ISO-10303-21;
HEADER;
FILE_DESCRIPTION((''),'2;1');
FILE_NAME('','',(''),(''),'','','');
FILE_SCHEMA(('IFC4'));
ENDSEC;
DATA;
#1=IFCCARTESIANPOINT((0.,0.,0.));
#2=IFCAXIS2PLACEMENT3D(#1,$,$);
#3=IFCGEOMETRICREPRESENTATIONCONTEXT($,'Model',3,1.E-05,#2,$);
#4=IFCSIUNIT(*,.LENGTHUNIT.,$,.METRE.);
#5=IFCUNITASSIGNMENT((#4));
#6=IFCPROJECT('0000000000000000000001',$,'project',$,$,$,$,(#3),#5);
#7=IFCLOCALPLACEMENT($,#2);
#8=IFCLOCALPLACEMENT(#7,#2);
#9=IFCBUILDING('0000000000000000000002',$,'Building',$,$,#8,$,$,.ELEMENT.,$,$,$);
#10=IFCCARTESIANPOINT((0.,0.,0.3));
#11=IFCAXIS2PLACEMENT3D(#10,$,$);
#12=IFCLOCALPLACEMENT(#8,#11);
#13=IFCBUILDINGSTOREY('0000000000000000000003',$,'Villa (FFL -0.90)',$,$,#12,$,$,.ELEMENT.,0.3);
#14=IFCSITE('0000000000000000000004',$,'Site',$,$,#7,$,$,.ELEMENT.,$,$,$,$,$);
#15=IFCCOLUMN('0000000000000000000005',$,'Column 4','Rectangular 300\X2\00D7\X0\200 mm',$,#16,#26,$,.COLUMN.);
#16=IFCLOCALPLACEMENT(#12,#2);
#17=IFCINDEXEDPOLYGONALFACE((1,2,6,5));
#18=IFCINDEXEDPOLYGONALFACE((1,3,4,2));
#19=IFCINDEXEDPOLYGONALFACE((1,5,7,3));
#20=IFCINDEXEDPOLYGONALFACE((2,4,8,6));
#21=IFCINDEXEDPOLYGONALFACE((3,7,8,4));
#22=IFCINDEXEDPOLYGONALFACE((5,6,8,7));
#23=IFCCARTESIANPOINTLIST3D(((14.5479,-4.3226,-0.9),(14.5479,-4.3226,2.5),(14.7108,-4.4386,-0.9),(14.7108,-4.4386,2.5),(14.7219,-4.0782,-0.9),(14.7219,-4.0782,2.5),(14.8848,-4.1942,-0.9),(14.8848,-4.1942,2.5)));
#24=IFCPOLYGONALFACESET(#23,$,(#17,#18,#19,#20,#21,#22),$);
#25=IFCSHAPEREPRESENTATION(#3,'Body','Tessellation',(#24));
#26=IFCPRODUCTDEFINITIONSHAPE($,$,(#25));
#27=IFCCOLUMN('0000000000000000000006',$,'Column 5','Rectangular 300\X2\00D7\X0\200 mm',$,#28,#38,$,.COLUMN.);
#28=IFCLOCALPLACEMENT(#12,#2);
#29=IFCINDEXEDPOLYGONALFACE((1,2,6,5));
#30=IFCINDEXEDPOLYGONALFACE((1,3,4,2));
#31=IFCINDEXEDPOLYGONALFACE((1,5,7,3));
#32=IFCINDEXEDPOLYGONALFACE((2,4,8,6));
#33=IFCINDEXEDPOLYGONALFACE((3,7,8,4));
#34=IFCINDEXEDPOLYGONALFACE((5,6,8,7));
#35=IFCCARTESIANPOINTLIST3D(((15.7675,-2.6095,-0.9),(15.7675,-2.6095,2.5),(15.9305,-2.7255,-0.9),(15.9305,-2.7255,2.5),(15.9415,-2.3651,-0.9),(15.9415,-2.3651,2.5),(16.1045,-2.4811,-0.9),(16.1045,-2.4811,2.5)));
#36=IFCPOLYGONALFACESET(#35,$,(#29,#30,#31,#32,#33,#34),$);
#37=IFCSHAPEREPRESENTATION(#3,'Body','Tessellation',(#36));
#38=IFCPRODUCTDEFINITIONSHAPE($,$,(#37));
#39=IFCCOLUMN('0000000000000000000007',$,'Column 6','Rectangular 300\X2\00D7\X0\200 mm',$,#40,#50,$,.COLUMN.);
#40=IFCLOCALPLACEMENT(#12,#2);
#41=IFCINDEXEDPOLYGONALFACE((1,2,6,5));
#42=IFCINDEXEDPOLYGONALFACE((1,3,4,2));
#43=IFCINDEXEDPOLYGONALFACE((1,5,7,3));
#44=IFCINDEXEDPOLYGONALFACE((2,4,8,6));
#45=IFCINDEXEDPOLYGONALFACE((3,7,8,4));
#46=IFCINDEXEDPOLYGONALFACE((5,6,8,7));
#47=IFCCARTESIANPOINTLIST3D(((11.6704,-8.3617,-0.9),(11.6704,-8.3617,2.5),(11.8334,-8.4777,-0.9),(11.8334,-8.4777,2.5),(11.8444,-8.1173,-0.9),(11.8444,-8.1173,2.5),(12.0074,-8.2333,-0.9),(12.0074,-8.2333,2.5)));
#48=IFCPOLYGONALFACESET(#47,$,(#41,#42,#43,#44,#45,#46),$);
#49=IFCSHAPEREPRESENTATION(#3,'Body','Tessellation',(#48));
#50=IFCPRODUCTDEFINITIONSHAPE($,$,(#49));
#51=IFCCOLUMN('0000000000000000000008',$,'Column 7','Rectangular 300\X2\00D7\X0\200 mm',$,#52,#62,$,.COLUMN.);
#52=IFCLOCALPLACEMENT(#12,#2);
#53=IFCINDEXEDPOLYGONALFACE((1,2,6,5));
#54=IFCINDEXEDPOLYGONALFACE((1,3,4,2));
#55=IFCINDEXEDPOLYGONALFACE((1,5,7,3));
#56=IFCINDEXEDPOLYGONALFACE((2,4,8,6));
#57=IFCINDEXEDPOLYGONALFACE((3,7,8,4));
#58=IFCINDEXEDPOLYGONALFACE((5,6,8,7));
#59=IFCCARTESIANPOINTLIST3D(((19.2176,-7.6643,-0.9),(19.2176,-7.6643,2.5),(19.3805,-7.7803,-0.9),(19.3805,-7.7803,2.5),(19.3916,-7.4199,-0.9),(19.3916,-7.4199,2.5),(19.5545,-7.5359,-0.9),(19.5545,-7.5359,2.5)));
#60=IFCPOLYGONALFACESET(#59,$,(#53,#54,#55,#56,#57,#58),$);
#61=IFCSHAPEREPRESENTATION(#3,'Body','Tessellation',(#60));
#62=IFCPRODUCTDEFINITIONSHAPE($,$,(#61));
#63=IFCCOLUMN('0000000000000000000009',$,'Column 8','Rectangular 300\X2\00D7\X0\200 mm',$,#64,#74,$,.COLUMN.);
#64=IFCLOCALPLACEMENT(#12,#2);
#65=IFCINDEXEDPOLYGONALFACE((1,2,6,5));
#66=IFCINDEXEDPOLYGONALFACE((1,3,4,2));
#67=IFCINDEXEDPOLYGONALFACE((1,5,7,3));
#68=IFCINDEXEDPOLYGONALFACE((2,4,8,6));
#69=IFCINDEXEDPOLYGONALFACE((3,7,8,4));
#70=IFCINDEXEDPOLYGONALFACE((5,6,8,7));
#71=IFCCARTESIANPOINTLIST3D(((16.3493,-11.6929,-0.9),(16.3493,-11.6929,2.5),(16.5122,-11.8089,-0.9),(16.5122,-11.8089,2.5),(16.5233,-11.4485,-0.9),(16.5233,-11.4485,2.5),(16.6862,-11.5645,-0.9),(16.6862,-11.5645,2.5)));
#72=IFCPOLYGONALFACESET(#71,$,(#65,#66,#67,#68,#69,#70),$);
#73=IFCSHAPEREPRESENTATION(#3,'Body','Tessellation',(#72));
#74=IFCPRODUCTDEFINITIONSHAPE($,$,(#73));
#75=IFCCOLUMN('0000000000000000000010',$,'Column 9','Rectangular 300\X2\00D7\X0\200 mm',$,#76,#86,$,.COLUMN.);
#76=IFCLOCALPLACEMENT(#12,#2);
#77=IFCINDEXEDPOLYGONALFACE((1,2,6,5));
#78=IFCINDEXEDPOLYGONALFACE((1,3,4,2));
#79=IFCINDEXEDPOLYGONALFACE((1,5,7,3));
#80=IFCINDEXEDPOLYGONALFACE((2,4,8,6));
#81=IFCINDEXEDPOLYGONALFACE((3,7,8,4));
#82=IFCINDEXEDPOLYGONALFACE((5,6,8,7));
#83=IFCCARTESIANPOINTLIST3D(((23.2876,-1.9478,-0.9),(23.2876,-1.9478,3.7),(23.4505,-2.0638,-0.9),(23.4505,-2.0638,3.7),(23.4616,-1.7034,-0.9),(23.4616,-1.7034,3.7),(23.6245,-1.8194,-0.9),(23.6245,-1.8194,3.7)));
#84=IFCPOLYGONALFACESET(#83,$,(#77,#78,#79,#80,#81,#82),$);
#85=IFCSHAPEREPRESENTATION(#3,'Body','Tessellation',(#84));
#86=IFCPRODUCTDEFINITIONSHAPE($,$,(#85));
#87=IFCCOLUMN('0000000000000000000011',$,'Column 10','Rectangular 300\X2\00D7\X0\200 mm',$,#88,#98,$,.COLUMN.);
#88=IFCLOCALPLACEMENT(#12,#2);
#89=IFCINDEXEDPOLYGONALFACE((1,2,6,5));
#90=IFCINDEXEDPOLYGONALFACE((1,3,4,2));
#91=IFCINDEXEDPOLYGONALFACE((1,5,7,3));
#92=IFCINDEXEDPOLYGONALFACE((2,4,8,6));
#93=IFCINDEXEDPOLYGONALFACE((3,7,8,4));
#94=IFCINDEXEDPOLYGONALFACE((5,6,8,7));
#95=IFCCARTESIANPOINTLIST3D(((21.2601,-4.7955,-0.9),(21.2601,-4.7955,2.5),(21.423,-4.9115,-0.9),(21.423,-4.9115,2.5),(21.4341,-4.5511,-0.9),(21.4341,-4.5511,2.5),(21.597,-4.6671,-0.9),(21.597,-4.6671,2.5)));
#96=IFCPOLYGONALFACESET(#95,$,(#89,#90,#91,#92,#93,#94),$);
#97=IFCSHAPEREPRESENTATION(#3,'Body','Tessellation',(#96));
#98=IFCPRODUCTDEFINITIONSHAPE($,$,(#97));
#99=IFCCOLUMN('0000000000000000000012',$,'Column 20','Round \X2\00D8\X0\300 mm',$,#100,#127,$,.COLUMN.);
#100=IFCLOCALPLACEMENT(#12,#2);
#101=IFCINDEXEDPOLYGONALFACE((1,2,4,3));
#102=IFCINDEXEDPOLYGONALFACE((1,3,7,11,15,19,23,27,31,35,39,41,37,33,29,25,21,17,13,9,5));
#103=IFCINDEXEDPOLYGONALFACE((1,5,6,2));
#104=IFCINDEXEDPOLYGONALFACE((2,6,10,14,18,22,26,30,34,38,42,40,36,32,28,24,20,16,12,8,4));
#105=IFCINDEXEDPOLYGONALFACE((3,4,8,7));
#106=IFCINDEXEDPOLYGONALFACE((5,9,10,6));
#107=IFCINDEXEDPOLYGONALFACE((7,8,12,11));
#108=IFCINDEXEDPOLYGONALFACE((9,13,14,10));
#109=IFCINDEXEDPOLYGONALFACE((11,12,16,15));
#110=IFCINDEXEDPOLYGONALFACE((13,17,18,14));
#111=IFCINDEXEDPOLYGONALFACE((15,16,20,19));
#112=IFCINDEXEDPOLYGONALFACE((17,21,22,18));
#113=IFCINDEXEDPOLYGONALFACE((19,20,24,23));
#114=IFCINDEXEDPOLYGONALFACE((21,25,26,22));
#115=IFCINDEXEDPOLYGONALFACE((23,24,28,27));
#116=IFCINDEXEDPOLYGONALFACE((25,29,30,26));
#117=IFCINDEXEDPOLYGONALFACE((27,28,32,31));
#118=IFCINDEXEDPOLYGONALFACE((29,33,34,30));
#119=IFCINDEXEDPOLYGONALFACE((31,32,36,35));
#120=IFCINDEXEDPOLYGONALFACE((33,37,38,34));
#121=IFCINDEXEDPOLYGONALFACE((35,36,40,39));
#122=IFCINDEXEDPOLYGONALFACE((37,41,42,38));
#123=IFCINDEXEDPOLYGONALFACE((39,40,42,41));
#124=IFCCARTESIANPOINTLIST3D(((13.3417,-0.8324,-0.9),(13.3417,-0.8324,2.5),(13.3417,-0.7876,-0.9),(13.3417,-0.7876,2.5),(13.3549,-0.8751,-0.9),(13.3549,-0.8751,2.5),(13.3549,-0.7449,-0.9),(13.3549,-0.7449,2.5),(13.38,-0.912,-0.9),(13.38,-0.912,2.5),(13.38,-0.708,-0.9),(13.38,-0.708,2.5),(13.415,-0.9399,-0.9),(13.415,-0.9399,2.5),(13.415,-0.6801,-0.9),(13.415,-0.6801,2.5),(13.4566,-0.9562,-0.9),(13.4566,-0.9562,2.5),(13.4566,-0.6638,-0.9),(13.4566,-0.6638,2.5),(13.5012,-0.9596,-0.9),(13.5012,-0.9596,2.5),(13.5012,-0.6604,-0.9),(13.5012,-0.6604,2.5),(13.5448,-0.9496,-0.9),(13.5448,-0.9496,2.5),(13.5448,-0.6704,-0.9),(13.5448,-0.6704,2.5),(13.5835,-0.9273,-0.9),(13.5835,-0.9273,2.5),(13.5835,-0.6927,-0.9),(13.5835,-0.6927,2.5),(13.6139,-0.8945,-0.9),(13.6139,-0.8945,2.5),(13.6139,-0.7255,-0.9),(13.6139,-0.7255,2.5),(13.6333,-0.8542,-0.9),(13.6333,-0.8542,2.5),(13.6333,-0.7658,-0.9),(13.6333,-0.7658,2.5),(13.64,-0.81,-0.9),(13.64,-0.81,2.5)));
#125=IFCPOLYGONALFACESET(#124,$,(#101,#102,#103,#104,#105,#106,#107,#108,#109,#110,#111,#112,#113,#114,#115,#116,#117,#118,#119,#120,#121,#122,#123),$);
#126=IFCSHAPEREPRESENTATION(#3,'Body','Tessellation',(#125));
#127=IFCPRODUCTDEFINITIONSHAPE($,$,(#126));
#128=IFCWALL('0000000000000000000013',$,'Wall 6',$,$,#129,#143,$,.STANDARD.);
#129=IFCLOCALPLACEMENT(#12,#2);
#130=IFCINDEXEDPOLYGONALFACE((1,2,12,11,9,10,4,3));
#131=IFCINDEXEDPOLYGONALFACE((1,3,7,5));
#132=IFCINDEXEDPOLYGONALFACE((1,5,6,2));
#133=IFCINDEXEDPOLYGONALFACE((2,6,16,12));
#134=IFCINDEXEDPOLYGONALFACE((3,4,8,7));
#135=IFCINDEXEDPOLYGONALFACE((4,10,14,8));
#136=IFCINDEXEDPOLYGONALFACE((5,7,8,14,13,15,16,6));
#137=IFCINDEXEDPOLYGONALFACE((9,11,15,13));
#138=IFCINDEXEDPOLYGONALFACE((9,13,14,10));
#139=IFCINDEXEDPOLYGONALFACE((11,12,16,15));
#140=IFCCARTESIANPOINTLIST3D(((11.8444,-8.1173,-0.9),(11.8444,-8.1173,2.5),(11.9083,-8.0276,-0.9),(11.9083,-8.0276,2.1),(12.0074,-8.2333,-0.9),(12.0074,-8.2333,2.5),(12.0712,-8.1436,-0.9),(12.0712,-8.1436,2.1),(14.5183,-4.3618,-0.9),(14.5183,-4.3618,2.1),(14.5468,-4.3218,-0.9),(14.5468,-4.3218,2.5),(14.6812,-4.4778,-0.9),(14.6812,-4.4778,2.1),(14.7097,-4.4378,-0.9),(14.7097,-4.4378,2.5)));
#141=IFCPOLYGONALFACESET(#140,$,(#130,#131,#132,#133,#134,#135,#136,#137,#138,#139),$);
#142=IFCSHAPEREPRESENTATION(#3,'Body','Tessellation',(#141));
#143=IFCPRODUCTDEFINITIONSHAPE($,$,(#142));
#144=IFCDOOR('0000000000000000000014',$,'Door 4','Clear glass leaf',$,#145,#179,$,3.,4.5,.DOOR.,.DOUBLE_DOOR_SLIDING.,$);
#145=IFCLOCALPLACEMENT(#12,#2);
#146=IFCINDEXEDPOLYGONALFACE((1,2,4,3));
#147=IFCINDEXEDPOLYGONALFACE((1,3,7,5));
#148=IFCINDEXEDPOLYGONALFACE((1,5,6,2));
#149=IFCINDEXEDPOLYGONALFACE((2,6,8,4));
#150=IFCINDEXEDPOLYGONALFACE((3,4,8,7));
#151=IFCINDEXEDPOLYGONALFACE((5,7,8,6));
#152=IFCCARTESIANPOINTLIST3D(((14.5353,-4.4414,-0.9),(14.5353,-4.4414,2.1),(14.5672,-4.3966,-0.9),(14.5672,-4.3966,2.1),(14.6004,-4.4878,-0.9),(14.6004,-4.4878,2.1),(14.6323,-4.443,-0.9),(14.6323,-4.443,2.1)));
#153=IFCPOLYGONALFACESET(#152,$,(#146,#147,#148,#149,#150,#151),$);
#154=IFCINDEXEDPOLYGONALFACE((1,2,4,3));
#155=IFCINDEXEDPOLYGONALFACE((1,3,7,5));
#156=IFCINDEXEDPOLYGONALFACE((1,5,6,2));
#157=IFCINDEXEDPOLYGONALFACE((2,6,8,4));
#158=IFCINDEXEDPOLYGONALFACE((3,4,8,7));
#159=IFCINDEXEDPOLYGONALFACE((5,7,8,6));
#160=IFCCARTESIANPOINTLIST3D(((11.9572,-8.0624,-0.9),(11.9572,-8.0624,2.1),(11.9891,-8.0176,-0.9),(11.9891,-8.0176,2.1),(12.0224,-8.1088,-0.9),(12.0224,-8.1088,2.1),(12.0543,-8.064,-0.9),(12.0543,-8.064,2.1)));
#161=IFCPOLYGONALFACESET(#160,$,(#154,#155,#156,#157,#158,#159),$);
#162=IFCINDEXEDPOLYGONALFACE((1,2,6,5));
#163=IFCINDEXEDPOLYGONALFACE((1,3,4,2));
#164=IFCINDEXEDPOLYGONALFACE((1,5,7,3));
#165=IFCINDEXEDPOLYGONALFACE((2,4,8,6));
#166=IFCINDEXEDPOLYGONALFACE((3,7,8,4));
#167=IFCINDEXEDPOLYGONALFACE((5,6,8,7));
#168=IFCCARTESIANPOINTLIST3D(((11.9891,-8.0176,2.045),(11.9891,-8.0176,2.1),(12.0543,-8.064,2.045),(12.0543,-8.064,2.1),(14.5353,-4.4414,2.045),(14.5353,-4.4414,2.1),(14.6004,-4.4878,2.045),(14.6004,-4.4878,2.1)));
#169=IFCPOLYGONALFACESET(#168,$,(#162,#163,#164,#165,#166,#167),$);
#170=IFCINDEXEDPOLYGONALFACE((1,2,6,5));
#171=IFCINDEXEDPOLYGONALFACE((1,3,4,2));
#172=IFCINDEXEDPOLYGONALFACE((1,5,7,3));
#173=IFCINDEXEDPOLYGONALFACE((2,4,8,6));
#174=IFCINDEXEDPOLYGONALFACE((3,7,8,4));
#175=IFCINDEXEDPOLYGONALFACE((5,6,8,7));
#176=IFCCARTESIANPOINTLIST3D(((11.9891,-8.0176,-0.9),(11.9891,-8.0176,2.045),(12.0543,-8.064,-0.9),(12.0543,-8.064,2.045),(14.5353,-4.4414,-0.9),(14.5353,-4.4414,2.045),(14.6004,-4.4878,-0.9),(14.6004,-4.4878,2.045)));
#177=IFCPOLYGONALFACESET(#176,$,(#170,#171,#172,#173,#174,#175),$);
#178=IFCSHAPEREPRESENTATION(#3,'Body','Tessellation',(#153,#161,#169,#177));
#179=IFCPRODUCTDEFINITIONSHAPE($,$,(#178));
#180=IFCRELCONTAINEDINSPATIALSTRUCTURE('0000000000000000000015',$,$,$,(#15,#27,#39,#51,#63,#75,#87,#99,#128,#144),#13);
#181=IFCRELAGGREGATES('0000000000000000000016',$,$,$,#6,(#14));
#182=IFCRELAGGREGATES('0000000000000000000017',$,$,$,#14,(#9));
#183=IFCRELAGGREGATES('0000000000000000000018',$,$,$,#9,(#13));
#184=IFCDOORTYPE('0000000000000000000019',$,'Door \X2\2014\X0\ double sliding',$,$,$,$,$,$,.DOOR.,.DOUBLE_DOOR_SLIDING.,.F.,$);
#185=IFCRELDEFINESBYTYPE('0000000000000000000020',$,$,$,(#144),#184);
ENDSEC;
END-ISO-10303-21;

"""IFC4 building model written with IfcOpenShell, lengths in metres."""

from ifc_helpers import new_model, si_unit, frame, frame_2d, origin, origin_2d, place, context, project, spatial, polyline, rectangle, circle, outline, extrude, type_object, element, fill, save


model = new_model("IFC4")

# Units and contexts
model_context = context("Model", 3, precision=1e-05, world=origin())
ifc_project = project(units=[si_unit("LENGTHUNIT", "METRE")], contexts=[model_context])

# Site, building, storey
site_placement = place(None, origin())
site = spatial("IfcSite", under=ifc_project, at=site_placement, Name="Site", CompositionType="ELEMENT")
building_placement = place(site_placement, origin())
building = spatial("IfcBuilding", under=site, at=building_placement, Name="Building", CompositionType="ELEMENT")
storey_placement = place(building_placement, frame((0.0, 0.0, 0.3)))
storey = spatial("IfcBuildingStorey", under=building, at=storey_placement, Name="Villa (FFL -0.90)", CompositionType="ELEMENT", Elevation=0.3)

# Columns
for number, where, z_axis, x_axis, name in (
    (1, (14.7163, -4.2584, -0.9), (0.0, 0.0, 1.0), (0.579992, 0.814622, 0.0), "Column 4"),
    (2, (15.936, -2.5453, -0.9), (0.0, 0.0, 1.0), (0.579992, 0.814622, 0.0), "Column 5"),
    (3, (11.8389, -8.2975, -0.9), (0.0, 0.0, 1.0), (0.579992, 0.814622, 0.0), "Column 6"),
    (4, (19.386, -7.6001, -0.9), (0.0, 0.0, 1.0), (0.579992, 0.814622, 0.0), "Column 7"),
    (5, (16.5177, -11.6287, -0.9), (0.0, 0.0, 1.0), (0.579992, 0.814622, 0.0), "Column 8"),
):
    element("IfcColumn", number, at=place(storey_placement, frame(where, z_axis=z_axis, x_axis=x_axis)), inside=storey, Name=name, Description="Rectangular 300×200 mm", PredefinedType="COLUMN", context=model_context, shape_type="SweptSolid", body=[
        extrude(outline(polyline([(-0.15, -0.1), (0.15, -0.1), (0.15, 0.1), (-0.15, 0.1), (-0.15, -0.1)])), origin(), (0.0, 0.0, 1.0), 3.4),
    ])
column_1_placement = place(storey_placement, frame((23.456, -1.8836, -0.9), z_axis=(0.0, 0.0, 1.0), x_axis=(0.579992, 0.814622, 0.0)))
element("IfcColumn", 6, at=column_1_placement, inside=storey, Name="Column 9", Description="Rectangular 300×200 mm", PredefinedType="COLUMN", context=model_context, shape_type="SweptSolid", body=[
    extrude(outline(polyline([(-0.15, -0.1), (0.15, -0.1), (0.15, 0.1), (-0.15, 0.1), (-0.15, -0.1)])), origin(), (0.0, 0.0, 1.0), 4.6),
])
column_2_placement = place(storey_placement, frame((21.4286, -4.7313, -0.9), z_axis=(0.0, 0.0, 1.0), x_axis=(0.579992, 0.814622, 0.0)))
element("IfcColumn", 7, at=column_2_placement, inside=storey, Name="Column 10", Description="Rectangular 300×200 mm", PredefinedType="COLUMN", context=model_context, shape_type="SweptSolid", body=[
    extrude(outline(polyline([(-0.15, -0.1), (0.15, -0.1), (0.15, 0.1), (-0.15, 0.1), (-0.15, -0.1)])), origin(), (0.0, 0.0, 1.0), 3.4),
])
column_3_placement = place(storey_placement, frame((13.49, -0.81, -0.9), z_axis=(0.0, 0.0, 1.0), x_axis=(1.0, 0.0, 0.0)))
element("IfcColumn", 8, at=column_3_placement, inside=storey, Name="Column 20", Description="Round Ø300 mm", PredefinedType="COLUMN", context=model_context, shape_type="SweptSolid", body=[
    extrude(circle(Radius=0.15, at=origin_2d()), origin(), (0.0, 0.0, 1.0), 3.4),
])

# Wall, opening, door
wall_1_placement = place(storey_placement, frame((14.6282, -4.3798, -0.9), z_axis=(0.0, 0.0, 1.0), x_axis=(-0.579992, -0.814622, 0.0)))
wall_1 = element("IfcWall", 9, at=wall_1_placement, inside=storey, Name="Wall 6", PredefinedType="STANDARD", context=model_context, shape_type="SweptSolid", body=[
    extrude(rectangle(XDim=4.6592, YDim=0.2, at=frame_2d((2.3296, 0.0))), origin(), (0.0, 0.0, 1.0), 3.4),
])
opening_1_placement = place(storey_placement, frame((14.5997, -4.4198, -0.9), z_axis=(0.0, 0.0, 1.0), x_axis=(-0.579992, -0.814622, 0.0)))
opening_1 = element("IfcOpeningElement", 10, at=opening_1_placement, cuts=wall_1, PredefinedType="OPENING", context=model_context, shape_type="SweptSolid", body=[
    extrude(rectangle(XDim=4.5, YDim=0.26, at=frame_2d((2.25, 0.0))), origin(), (0.0, 0.0, 1.0), 3.0),
])
door_type = type_object("IfcDoorType", Name="Door — double sliding", OperationType="DOUBLE_DOOR_SLIDING", ParameterTakesPrecedence=False, PredefinedType="DOOR")
door_1_placement = place(storey_placement, frame((14.5997, -4.4198, -0.9), z_axis=(0.0, 0.0, 1.0), x_axis=(-0.579992, -0.814622, 0.0)))
door_1 = element("IfcDoor", 11, at=door_1_placement, inside=storey, type_object=door_type, Name="Door 4", Description="Clear glass leaf", OperationType="DOUBLE_DOOR_SLIDING", OverallHeight=3.0, OverallWidth=4.5, PredefinedType="DOOR", context=model_context, shape_type="SweptSolid", body=[
    extrude(rectangle(XDim=0.055, YDim=0.08, at=frame_2d((0.0275, 0.0))), origin(), (0.0, 0.0, 1.0), 3.0),
    extrude(rectangle(XDim=0.055, YDim=0.08, at=frame_2d((4.4725, 0.0))), origin(), (0.0, 0.0, 1.0), 3.0),
    extrude(rectangle(XDim=4.39, YDim=0.08, at=frame_2d((2.25, 0.0))), frame((0.0, 0.0, 2.945)), (0.0, 0.0, 1.0), 0.055),
    extrude(rectangle(XDim=4.39, YDim=0.08, at=frame_2d((2.25, 0.0))), origin(), (0.0, 0.0, 1.0), 2.945),
])
fill(opening_1, door_1)

save(model, "model.ifc")
